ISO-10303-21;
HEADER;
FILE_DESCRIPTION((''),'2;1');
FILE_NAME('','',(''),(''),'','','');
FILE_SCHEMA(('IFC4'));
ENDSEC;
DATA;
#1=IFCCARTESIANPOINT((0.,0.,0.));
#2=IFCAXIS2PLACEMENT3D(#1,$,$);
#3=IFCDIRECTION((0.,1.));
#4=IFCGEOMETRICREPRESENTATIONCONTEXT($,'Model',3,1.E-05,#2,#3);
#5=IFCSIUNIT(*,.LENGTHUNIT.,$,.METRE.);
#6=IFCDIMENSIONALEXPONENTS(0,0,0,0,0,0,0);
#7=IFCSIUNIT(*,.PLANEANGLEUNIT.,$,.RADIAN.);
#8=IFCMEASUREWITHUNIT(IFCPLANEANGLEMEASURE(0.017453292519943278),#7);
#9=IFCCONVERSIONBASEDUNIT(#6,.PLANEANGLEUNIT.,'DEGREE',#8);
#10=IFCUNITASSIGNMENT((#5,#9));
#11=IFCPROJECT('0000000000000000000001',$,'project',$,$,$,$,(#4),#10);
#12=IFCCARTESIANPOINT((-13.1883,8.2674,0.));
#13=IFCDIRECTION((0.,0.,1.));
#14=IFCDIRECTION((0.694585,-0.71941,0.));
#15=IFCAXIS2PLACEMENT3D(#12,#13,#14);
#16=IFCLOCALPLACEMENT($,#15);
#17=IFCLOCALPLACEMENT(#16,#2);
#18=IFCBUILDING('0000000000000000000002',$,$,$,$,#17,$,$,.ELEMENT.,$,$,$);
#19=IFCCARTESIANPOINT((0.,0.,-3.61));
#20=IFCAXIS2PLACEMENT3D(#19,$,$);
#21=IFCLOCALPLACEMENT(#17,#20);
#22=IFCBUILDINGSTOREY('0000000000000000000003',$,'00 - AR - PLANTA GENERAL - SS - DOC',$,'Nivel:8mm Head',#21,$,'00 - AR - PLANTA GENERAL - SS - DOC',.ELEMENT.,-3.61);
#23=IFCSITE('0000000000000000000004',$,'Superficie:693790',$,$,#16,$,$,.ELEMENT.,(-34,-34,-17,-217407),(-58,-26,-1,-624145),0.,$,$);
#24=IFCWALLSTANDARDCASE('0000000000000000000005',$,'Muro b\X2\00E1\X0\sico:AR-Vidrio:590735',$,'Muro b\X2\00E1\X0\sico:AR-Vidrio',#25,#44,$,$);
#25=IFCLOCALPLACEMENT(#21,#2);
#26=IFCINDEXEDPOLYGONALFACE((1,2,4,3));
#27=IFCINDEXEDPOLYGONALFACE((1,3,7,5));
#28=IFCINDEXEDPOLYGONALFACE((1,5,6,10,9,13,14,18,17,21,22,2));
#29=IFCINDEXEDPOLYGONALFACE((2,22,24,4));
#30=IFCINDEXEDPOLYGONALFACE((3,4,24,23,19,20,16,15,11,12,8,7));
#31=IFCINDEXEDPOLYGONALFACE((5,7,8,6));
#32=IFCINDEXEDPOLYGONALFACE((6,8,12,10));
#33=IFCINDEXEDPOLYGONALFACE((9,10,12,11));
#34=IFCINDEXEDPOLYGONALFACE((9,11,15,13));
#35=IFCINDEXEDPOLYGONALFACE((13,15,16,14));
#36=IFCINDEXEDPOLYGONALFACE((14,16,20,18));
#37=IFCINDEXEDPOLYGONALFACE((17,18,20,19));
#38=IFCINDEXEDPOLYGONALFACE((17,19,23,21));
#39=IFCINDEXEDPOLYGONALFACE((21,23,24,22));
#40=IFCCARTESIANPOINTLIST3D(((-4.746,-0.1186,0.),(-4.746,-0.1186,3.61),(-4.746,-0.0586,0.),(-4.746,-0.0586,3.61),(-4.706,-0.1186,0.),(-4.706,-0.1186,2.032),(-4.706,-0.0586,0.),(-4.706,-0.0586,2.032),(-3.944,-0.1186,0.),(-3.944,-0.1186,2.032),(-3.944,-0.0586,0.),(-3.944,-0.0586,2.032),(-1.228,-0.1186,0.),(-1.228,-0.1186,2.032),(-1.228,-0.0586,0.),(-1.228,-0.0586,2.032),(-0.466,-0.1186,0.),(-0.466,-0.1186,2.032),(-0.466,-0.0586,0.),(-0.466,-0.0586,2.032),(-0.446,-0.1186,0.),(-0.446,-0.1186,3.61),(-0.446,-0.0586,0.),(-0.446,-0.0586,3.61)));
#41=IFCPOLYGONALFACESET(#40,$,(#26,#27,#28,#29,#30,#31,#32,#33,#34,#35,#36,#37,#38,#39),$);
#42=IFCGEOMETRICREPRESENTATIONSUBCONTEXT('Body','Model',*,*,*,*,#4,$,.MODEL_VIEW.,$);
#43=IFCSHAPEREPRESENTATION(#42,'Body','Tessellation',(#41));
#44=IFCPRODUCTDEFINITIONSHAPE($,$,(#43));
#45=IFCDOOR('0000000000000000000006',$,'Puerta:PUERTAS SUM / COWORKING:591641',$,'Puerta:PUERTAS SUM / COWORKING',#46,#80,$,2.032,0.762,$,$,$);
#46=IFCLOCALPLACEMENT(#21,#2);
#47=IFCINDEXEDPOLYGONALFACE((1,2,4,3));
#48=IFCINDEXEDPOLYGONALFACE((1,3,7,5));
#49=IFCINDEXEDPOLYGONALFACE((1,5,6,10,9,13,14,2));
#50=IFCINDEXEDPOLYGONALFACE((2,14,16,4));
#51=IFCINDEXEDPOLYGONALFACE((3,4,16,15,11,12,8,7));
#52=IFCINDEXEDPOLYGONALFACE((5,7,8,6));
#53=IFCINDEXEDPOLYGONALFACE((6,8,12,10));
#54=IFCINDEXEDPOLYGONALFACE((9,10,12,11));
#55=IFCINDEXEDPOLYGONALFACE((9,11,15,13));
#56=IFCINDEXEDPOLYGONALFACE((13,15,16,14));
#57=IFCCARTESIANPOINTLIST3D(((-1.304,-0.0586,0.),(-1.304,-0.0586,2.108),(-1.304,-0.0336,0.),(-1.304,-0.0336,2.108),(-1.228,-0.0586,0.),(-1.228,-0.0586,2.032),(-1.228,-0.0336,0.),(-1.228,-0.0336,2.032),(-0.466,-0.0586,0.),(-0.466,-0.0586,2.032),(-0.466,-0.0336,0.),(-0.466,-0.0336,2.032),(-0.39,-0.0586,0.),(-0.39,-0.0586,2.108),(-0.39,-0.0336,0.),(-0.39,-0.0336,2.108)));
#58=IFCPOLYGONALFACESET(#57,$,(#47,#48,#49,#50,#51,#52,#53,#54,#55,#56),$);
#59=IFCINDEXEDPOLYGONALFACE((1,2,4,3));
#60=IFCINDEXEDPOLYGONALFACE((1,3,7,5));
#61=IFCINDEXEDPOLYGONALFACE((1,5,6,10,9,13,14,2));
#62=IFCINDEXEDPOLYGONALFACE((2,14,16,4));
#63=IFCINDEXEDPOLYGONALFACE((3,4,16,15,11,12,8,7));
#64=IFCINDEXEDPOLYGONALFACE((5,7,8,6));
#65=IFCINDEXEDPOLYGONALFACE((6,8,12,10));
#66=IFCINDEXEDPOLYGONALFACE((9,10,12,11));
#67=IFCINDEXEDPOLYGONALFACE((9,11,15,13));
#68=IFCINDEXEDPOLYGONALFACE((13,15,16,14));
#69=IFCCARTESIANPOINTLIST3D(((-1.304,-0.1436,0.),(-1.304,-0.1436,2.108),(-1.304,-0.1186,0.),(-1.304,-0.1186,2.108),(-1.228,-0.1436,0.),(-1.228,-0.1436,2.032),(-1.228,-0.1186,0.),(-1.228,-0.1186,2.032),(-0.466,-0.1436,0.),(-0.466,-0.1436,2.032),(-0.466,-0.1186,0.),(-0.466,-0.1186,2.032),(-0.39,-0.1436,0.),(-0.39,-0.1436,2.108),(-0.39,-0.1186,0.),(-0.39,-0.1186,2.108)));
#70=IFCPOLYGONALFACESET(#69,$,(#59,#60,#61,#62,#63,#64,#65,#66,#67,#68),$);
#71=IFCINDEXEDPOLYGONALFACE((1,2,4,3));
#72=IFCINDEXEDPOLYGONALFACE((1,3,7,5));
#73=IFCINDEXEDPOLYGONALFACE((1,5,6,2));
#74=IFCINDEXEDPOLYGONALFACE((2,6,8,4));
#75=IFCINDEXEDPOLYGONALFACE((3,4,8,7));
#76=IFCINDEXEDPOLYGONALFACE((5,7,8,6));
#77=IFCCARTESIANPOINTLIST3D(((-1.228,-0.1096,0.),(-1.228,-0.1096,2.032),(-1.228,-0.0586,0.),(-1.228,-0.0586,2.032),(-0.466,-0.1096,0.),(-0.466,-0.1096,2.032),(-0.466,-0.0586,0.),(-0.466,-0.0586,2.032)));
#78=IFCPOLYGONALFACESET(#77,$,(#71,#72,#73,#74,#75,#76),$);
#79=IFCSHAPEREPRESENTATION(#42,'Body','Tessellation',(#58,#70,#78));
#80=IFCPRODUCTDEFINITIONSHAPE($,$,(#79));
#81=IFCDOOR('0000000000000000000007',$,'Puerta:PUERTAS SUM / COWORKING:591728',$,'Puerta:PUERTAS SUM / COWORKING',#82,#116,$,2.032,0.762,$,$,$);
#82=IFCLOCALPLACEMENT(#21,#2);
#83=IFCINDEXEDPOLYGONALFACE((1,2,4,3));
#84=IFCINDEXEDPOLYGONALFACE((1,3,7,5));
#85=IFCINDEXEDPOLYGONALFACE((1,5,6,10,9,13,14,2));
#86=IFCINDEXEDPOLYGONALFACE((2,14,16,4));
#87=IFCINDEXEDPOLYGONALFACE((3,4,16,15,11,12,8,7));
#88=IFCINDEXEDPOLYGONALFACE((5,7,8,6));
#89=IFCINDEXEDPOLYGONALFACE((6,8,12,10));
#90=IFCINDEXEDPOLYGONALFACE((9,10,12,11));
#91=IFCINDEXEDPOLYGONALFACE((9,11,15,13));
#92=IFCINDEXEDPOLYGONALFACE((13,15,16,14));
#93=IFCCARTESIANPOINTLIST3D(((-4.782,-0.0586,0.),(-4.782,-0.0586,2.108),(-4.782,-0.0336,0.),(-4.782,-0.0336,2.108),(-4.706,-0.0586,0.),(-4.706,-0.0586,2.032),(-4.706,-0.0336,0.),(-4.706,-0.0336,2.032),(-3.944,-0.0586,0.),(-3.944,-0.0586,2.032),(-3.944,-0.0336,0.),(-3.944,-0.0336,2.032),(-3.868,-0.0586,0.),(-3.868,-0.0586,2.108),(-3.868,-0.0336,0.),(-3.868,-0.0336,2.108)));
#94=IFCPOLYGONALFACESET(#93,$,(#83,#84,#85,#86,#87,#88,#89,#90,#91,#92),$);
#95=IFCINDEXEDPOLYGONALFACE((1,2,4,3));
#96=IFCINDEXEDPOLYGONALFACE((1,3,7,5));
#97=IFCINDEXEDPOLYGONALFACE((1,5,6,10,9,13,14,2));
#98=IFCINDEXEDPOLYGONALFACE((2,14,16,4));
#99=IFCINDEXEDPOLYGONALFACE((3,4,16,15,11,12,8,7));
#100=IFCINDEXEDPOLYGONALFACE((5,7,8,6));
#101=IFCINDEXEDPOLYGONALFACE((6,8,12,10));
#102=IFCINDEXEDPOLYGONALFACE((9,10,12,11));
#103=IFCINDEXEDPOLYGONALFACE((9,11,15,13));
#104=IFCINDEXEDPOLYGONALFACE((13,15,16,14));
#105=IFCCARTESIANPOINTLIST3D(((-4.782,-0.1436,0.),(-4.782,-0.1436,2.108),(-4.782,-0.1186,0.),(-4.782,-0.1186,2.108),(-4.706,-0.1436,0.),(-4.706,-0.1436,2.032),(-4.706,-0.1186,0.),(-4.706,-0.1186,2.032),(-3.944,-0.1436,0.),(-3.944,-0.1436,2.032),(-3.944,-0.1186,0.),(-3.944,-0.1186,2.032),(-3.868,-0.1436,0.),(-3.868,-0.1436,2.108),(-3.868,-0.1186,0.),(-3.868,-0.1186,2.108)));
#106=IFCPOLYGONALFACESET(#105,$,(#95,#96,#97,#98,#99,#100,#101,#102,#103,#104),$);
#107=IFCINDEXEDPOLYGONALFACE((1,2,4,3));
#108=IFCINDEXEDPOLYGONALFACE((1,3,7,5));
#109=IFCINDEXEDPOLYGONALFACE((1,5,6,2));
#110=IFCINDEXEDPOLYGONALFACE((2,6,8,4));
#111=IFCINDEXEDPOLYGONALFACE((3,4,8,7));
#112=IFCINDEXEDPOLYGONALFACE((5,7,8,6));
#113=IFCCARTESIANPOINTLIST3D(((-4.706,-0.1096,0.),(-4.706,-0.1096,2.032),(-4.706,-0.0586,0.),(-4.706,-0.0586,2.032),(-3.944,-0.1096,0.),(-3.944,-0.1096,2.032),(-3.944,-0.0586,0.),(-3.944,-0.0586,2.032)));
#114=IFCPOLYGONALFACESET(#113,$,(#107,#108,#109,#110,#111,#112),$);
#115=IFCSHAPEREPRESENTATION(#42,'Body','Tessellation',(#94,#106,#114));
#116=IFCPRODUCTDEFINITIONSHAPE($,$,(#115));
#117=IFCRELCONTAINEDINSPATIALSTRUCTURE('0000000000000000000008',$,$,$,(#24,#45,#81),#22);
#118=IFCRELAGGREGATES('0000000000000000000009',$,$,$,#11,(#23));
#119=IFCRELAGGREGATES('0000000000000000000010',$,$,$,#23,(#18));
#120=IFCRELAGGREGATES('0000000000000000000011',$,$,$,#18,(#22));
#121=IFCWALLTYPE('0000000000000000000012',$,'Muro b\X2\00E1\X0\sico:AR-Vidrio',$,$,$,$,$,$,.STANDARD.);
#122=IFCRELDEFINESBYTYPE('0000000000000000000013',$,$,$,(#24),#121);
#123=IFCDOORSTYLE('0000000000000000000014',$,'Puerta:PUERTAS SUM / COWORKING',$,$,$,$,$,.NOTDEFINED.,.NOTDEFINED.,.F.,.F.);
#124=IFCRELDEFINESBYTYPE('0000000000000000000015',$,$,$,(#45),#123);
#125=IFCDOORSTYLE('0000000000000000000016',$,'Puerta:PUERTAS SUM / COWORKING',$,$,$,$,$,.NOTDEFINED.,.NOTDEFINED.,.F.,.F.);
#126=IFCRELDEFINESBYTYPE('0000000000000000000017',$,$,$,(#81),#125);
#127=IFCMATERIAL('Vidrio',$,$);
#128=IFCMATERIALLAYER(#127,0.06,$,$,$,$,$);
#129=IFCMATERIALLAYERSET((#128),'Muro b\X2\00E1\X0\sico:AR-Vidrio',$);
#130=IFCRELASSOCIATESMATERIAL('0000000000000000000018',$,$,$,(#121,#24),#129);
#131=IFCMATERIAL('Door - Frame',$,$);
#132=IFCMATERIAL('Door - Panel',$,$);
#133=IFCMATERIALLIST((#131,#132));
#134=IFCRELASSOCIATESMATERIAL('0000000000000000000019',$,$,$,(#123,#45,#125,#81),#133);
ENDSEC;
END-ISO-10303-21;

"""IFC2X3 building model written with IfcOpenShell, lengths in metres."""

from ifc_helpers import new_model, entity, si_unit, converted_unit, direction, frame, frame_2d, origin, origin_2d_with_axis, place, context, subcontext, project, spatial, polyline, rectangle, outline, extrude, source, transform, mapped, material, material_list, layer, layer_set, layer_usage, type_object, type_shapes, element, fill, save


model = new_model("IFC2X3")

# Units and contexts
model_context = context("Model", 3, precision=1e-05, world=origin(), true_north=direction((0.0, 1.0)))
body_context = subcontext(model_context, "Body", "Model", "MODEL_VIEW")
ifc_project = project(units=[si_unit("LENGTHUNIT", "METRE"), converted_unit("PLANEANGLEUNIT", "DEGREE", entity("IfcPlaneAngleMeasure", 0.017453292519943278), si_unit("PLANEANGLEUNIT", "RADIAN"), dimensions=[0, 0, 0, 0, 0, 0, 0])], contexts=[model_context])

# Site, building, storey
site_placement = place(None, frame((-13.1883, 8.2674, 0.0), z_axis=(0.0, 0.0, 1.0), x_axis=(0.694585, -0.71941, 0.0)))
site = spatial("IfcSite", under=ifc_project, at=site_placement, Name="Superficie:693790", CompositionType="ELEMENT", RefLatitude=(-34, -34, -17, -217407), RefLongitude=(-58, -26, -1, -624145), RefElevation=0.0)
building_placement = place(site_placement, origin())
building = spatial("IfcBuilding", under=site, at=building_placement, CompositionType="ELEMENT")
storey_placement = place(building_placement, frame((0.0, 0.0, -3.61)))
storey = spatial("IfcBuildingStorey", under=building, at=storey_placement, Name="00 - AR - PLANTA GENERAL - SS - DOC", ObjectType="Nivel:8mm Head", LongName="00 - AR - PLANTA GENERAL - SS - DOC", CompositionType="ELEMENT", Elevation=-3.61)

# Shared definitions
ifc_material_1 = material(Name="Door - Frame")
ifc_material_2 = material(Name="Door - Panel")
ifc_material_list_1 = material_list([ifc_material_1, ifc_material_2])

# Shared definitions
ifc_material_3 = material(Name="Vidrio")

# Shared definitions
ifc_layer_1 = layer(ifc_material_3, 0.06)
ifc_layer_set_1 = layer_set([ifc_layer_1], Name="Muro básico:AR-Vidrio")
wall_type_1 = type_object("IfcWallType", Name="Muro básico:AR-Vidrio", PredefinedType="STANDARD", material=ifc_layer_set_1)
door_style_1 = type_object("IfcDoorStyle", Name="Puerta:PUERTAS SUM / COWORKING", ConstructionType="NOTDEFINED", OperationType="NOTDEFINED", ParameterTakesPrecedence=False, Sizeable=False, material=ifc_material_list_1)
shared_shape_1 = source(origin(), body_context, "Body", "SweptSolid", [
    extrude(outline(polyline([(-0.457, -1.073), (0.457, -1.073), (0.457, 1.035), (0.381, 1.035), (0.381, -0.997), (-0.381, -0.997), (-0.381, 1.035), (-0.457, 1.035), (-0.457, -1.073)])), frame((0.381, 0.06, 1.035), z_axis=(0.0, 1.0, 0.0), x_axis=(1.0, 0.0, 0.0)), (0.0, 0.0, 1.0), 0.025),
    extrude(outline(polyline([(-1.073, -0.457), (1.035, -0.457), (1.035, -0.381), (-0.997, -0.381), (-0.997, 0.381), (1.035, 0.381), (1.035, 0.457), (-1.073, 0.457), (-1.073, -0.457)])), frame((0.381, -0.025, 1.035), z_axis=(0.0, 1.0, 0.0), x_axis=(0.0, 0.0, -1.0)), (0.0, 0.0, 1.0), 0.025),
    extrude(rectangle(XDim=0.051, YDim=0.762, at=origin_2d_with_axis()), frame((0.381, 0.0345, 0.0), z_axis=(0.0, 0.0, 1.0), x_axis=(0.0, 1.0, 0.0)), (0.0, 0.0, 1.0), 2.032),
])
type_shapes(door_style_1, [shared_shape_1])

# Wall, openings, doors
ifc_layer_usage_1 = layer_usage(ifc_layer_set_1, "AXIS2", "NEGATIVE", 0.03)
wall_1_placement = place(storey_placement, frame((-4.746, -0.0886, 0.0)))
wall_1 = element("IfcWallStandardCase", 1, at=wall_1_placement, inside=storey, type_object=wall_type_1, material=ifc_layer_usage_1, Name="Muro básico:AR-Vidrio:590735", ObjectType="Muro básico:AR-Vidrio", context=body_context, shape_type="SweptSolid", body=[
    extrude(rectangle(XDim=4.3, YDim=0.06, at=frame_2d((2.15, 0.0), x_axis=(1.0, 0.0))), origin(), (0.0, 0.0, 1.0), 3.61),
])
opening_1_placement = place(wall_1_placement, frame((3.518, -0.03, 0.0)))
opening_1 = element("IfcOpeningElement", 2, at=opening_1_placement, cuts=wall_1, ObjectType="Opening", context=body_context, shape_type="SweptSolid", body=[
    extrude(rectangle(XDim=0.762, YDim=2.032, at=frame_2d((1.016, 0.381), x_axis=(0.0, 1.0))), frame((0.0, 0.0, 0.0), z_axis=(0.0, 1.0, 0.0), x_axis=(0.0, 0.0, 1.0)), (0.0, 0.0, 1.0), 0.06),
])
opening_2_placement = place(wall_1_placement, frame((0.04, -0.03, 0.0)))
opening_2 = element("IfcOpeningElement", 3, at=opening_2_placement, cuts=wall_1, ObjectType="Opening", context=body_context, shape_type="SweptSolid", body=[
    extrude(rectangle(XDim=0.762, YDim=2.032, at=frame_2d((1.016, 0.381), x_axis=(0.0, -1.0))), frame((0.0, 0.0, 0.0), z_axis=(0.0, 1.0, 0.0), x_axis=(0.0, 0.0, 1.0)), (0.0, 0.0, 1.0), 0.06),
])
door_1_placement = place(opening_1_placement, origin())
door_1 = element("IfcDoor", 4, at=door_1_placement, inside=storey, type_object=door_style_1, material=ifc_material_list_1, Name="Puerta:PUERTAS SUM / COWORKING:591641", ObjectType="Puerta:PUERTAS SUM / COWORKING", OverallHeight=2.032, OverallWidth=0.762, context=body_context, shape_type="MappedRepresentation", body=[
    mapped(shared_shape_1, transform((0.0, 0.0, 0.0), scale=1.0)),
])
fill(opening_1, door_1)
door_style_2 = type_object("IfcDoorStyle", Name="Puerta:PUERTAS SUM / COWORKING", ConstructionType="NOTDEFINED", OperationType="NOTDEFINED", ParameterTakesPrecedence=False, Sizeable=False, material=ifc_material_list_1)
shared_shape_2 = source(origin(), body_context, "Body", "SweptSolid", [
    extrude(outline(polyline([(-0.457, -1.073), (0.457, -1.073), (0.457, 1.035), (0.381, 1.035), (0.381, -0.997), (-0.381, -0.997), (-0.381, 1.035), (-0.457, 1.035), (-0.457, -1.073)])), frame((0.381, 0.085, 1.035), z_axis=(0.0, -1.0, 0.0), x_axis=(-1.0, 0.0, 0.0)), (0.0, 0.0, 1.0), 0.025),
    extrude(outline(polyline([(-1.073, -0.457), (1.035, -0.457), (1.035, -0.381), (-0.997, -0.381), (-0.997, 0.381), (1.035, 0.381), (1.035, 0.457), (-1.073, 0.457), (-1.073, -0.457)])), frame((0.381, 0.0, 1.035), z_axis=(0.0, -1.0, 0.0), x_axis=(0.0, 0.0, -1.0)), (0.0, 0.0, 1.0), 0.025),
    extrude(rectangle(XDim=0.762, YDim=0.051, at=origin_2d_with_axis()), frame((0.381, 0.0345, 0.0)), (0.0, 0.0, 1.0), 2.032),
])
type_shapes(door_style_2, [shared_shape_2])
door_2_placement = place(opening_2_placement, origin())
door_2 = element("IfcDoor", 5, at=door_2_placement, inside=storey, type_object=door_style_2, material=ifc_material_list_1, Name="Puerta:PUERTAS SUM / COWORKING:591728", ObjectType="Puerta:PUERTAS SUM / COWORKING", OverallHeight=2.032, OverallWidth=0.762, context=body_context, shape_type="MappedRepresentation", body=[
    mapped(shared_shape_2, transform((0.0, 0.0, 0.0), scale=1.0)),
])
fill(opening_2, door_2)

save(model, "model.ifc")
